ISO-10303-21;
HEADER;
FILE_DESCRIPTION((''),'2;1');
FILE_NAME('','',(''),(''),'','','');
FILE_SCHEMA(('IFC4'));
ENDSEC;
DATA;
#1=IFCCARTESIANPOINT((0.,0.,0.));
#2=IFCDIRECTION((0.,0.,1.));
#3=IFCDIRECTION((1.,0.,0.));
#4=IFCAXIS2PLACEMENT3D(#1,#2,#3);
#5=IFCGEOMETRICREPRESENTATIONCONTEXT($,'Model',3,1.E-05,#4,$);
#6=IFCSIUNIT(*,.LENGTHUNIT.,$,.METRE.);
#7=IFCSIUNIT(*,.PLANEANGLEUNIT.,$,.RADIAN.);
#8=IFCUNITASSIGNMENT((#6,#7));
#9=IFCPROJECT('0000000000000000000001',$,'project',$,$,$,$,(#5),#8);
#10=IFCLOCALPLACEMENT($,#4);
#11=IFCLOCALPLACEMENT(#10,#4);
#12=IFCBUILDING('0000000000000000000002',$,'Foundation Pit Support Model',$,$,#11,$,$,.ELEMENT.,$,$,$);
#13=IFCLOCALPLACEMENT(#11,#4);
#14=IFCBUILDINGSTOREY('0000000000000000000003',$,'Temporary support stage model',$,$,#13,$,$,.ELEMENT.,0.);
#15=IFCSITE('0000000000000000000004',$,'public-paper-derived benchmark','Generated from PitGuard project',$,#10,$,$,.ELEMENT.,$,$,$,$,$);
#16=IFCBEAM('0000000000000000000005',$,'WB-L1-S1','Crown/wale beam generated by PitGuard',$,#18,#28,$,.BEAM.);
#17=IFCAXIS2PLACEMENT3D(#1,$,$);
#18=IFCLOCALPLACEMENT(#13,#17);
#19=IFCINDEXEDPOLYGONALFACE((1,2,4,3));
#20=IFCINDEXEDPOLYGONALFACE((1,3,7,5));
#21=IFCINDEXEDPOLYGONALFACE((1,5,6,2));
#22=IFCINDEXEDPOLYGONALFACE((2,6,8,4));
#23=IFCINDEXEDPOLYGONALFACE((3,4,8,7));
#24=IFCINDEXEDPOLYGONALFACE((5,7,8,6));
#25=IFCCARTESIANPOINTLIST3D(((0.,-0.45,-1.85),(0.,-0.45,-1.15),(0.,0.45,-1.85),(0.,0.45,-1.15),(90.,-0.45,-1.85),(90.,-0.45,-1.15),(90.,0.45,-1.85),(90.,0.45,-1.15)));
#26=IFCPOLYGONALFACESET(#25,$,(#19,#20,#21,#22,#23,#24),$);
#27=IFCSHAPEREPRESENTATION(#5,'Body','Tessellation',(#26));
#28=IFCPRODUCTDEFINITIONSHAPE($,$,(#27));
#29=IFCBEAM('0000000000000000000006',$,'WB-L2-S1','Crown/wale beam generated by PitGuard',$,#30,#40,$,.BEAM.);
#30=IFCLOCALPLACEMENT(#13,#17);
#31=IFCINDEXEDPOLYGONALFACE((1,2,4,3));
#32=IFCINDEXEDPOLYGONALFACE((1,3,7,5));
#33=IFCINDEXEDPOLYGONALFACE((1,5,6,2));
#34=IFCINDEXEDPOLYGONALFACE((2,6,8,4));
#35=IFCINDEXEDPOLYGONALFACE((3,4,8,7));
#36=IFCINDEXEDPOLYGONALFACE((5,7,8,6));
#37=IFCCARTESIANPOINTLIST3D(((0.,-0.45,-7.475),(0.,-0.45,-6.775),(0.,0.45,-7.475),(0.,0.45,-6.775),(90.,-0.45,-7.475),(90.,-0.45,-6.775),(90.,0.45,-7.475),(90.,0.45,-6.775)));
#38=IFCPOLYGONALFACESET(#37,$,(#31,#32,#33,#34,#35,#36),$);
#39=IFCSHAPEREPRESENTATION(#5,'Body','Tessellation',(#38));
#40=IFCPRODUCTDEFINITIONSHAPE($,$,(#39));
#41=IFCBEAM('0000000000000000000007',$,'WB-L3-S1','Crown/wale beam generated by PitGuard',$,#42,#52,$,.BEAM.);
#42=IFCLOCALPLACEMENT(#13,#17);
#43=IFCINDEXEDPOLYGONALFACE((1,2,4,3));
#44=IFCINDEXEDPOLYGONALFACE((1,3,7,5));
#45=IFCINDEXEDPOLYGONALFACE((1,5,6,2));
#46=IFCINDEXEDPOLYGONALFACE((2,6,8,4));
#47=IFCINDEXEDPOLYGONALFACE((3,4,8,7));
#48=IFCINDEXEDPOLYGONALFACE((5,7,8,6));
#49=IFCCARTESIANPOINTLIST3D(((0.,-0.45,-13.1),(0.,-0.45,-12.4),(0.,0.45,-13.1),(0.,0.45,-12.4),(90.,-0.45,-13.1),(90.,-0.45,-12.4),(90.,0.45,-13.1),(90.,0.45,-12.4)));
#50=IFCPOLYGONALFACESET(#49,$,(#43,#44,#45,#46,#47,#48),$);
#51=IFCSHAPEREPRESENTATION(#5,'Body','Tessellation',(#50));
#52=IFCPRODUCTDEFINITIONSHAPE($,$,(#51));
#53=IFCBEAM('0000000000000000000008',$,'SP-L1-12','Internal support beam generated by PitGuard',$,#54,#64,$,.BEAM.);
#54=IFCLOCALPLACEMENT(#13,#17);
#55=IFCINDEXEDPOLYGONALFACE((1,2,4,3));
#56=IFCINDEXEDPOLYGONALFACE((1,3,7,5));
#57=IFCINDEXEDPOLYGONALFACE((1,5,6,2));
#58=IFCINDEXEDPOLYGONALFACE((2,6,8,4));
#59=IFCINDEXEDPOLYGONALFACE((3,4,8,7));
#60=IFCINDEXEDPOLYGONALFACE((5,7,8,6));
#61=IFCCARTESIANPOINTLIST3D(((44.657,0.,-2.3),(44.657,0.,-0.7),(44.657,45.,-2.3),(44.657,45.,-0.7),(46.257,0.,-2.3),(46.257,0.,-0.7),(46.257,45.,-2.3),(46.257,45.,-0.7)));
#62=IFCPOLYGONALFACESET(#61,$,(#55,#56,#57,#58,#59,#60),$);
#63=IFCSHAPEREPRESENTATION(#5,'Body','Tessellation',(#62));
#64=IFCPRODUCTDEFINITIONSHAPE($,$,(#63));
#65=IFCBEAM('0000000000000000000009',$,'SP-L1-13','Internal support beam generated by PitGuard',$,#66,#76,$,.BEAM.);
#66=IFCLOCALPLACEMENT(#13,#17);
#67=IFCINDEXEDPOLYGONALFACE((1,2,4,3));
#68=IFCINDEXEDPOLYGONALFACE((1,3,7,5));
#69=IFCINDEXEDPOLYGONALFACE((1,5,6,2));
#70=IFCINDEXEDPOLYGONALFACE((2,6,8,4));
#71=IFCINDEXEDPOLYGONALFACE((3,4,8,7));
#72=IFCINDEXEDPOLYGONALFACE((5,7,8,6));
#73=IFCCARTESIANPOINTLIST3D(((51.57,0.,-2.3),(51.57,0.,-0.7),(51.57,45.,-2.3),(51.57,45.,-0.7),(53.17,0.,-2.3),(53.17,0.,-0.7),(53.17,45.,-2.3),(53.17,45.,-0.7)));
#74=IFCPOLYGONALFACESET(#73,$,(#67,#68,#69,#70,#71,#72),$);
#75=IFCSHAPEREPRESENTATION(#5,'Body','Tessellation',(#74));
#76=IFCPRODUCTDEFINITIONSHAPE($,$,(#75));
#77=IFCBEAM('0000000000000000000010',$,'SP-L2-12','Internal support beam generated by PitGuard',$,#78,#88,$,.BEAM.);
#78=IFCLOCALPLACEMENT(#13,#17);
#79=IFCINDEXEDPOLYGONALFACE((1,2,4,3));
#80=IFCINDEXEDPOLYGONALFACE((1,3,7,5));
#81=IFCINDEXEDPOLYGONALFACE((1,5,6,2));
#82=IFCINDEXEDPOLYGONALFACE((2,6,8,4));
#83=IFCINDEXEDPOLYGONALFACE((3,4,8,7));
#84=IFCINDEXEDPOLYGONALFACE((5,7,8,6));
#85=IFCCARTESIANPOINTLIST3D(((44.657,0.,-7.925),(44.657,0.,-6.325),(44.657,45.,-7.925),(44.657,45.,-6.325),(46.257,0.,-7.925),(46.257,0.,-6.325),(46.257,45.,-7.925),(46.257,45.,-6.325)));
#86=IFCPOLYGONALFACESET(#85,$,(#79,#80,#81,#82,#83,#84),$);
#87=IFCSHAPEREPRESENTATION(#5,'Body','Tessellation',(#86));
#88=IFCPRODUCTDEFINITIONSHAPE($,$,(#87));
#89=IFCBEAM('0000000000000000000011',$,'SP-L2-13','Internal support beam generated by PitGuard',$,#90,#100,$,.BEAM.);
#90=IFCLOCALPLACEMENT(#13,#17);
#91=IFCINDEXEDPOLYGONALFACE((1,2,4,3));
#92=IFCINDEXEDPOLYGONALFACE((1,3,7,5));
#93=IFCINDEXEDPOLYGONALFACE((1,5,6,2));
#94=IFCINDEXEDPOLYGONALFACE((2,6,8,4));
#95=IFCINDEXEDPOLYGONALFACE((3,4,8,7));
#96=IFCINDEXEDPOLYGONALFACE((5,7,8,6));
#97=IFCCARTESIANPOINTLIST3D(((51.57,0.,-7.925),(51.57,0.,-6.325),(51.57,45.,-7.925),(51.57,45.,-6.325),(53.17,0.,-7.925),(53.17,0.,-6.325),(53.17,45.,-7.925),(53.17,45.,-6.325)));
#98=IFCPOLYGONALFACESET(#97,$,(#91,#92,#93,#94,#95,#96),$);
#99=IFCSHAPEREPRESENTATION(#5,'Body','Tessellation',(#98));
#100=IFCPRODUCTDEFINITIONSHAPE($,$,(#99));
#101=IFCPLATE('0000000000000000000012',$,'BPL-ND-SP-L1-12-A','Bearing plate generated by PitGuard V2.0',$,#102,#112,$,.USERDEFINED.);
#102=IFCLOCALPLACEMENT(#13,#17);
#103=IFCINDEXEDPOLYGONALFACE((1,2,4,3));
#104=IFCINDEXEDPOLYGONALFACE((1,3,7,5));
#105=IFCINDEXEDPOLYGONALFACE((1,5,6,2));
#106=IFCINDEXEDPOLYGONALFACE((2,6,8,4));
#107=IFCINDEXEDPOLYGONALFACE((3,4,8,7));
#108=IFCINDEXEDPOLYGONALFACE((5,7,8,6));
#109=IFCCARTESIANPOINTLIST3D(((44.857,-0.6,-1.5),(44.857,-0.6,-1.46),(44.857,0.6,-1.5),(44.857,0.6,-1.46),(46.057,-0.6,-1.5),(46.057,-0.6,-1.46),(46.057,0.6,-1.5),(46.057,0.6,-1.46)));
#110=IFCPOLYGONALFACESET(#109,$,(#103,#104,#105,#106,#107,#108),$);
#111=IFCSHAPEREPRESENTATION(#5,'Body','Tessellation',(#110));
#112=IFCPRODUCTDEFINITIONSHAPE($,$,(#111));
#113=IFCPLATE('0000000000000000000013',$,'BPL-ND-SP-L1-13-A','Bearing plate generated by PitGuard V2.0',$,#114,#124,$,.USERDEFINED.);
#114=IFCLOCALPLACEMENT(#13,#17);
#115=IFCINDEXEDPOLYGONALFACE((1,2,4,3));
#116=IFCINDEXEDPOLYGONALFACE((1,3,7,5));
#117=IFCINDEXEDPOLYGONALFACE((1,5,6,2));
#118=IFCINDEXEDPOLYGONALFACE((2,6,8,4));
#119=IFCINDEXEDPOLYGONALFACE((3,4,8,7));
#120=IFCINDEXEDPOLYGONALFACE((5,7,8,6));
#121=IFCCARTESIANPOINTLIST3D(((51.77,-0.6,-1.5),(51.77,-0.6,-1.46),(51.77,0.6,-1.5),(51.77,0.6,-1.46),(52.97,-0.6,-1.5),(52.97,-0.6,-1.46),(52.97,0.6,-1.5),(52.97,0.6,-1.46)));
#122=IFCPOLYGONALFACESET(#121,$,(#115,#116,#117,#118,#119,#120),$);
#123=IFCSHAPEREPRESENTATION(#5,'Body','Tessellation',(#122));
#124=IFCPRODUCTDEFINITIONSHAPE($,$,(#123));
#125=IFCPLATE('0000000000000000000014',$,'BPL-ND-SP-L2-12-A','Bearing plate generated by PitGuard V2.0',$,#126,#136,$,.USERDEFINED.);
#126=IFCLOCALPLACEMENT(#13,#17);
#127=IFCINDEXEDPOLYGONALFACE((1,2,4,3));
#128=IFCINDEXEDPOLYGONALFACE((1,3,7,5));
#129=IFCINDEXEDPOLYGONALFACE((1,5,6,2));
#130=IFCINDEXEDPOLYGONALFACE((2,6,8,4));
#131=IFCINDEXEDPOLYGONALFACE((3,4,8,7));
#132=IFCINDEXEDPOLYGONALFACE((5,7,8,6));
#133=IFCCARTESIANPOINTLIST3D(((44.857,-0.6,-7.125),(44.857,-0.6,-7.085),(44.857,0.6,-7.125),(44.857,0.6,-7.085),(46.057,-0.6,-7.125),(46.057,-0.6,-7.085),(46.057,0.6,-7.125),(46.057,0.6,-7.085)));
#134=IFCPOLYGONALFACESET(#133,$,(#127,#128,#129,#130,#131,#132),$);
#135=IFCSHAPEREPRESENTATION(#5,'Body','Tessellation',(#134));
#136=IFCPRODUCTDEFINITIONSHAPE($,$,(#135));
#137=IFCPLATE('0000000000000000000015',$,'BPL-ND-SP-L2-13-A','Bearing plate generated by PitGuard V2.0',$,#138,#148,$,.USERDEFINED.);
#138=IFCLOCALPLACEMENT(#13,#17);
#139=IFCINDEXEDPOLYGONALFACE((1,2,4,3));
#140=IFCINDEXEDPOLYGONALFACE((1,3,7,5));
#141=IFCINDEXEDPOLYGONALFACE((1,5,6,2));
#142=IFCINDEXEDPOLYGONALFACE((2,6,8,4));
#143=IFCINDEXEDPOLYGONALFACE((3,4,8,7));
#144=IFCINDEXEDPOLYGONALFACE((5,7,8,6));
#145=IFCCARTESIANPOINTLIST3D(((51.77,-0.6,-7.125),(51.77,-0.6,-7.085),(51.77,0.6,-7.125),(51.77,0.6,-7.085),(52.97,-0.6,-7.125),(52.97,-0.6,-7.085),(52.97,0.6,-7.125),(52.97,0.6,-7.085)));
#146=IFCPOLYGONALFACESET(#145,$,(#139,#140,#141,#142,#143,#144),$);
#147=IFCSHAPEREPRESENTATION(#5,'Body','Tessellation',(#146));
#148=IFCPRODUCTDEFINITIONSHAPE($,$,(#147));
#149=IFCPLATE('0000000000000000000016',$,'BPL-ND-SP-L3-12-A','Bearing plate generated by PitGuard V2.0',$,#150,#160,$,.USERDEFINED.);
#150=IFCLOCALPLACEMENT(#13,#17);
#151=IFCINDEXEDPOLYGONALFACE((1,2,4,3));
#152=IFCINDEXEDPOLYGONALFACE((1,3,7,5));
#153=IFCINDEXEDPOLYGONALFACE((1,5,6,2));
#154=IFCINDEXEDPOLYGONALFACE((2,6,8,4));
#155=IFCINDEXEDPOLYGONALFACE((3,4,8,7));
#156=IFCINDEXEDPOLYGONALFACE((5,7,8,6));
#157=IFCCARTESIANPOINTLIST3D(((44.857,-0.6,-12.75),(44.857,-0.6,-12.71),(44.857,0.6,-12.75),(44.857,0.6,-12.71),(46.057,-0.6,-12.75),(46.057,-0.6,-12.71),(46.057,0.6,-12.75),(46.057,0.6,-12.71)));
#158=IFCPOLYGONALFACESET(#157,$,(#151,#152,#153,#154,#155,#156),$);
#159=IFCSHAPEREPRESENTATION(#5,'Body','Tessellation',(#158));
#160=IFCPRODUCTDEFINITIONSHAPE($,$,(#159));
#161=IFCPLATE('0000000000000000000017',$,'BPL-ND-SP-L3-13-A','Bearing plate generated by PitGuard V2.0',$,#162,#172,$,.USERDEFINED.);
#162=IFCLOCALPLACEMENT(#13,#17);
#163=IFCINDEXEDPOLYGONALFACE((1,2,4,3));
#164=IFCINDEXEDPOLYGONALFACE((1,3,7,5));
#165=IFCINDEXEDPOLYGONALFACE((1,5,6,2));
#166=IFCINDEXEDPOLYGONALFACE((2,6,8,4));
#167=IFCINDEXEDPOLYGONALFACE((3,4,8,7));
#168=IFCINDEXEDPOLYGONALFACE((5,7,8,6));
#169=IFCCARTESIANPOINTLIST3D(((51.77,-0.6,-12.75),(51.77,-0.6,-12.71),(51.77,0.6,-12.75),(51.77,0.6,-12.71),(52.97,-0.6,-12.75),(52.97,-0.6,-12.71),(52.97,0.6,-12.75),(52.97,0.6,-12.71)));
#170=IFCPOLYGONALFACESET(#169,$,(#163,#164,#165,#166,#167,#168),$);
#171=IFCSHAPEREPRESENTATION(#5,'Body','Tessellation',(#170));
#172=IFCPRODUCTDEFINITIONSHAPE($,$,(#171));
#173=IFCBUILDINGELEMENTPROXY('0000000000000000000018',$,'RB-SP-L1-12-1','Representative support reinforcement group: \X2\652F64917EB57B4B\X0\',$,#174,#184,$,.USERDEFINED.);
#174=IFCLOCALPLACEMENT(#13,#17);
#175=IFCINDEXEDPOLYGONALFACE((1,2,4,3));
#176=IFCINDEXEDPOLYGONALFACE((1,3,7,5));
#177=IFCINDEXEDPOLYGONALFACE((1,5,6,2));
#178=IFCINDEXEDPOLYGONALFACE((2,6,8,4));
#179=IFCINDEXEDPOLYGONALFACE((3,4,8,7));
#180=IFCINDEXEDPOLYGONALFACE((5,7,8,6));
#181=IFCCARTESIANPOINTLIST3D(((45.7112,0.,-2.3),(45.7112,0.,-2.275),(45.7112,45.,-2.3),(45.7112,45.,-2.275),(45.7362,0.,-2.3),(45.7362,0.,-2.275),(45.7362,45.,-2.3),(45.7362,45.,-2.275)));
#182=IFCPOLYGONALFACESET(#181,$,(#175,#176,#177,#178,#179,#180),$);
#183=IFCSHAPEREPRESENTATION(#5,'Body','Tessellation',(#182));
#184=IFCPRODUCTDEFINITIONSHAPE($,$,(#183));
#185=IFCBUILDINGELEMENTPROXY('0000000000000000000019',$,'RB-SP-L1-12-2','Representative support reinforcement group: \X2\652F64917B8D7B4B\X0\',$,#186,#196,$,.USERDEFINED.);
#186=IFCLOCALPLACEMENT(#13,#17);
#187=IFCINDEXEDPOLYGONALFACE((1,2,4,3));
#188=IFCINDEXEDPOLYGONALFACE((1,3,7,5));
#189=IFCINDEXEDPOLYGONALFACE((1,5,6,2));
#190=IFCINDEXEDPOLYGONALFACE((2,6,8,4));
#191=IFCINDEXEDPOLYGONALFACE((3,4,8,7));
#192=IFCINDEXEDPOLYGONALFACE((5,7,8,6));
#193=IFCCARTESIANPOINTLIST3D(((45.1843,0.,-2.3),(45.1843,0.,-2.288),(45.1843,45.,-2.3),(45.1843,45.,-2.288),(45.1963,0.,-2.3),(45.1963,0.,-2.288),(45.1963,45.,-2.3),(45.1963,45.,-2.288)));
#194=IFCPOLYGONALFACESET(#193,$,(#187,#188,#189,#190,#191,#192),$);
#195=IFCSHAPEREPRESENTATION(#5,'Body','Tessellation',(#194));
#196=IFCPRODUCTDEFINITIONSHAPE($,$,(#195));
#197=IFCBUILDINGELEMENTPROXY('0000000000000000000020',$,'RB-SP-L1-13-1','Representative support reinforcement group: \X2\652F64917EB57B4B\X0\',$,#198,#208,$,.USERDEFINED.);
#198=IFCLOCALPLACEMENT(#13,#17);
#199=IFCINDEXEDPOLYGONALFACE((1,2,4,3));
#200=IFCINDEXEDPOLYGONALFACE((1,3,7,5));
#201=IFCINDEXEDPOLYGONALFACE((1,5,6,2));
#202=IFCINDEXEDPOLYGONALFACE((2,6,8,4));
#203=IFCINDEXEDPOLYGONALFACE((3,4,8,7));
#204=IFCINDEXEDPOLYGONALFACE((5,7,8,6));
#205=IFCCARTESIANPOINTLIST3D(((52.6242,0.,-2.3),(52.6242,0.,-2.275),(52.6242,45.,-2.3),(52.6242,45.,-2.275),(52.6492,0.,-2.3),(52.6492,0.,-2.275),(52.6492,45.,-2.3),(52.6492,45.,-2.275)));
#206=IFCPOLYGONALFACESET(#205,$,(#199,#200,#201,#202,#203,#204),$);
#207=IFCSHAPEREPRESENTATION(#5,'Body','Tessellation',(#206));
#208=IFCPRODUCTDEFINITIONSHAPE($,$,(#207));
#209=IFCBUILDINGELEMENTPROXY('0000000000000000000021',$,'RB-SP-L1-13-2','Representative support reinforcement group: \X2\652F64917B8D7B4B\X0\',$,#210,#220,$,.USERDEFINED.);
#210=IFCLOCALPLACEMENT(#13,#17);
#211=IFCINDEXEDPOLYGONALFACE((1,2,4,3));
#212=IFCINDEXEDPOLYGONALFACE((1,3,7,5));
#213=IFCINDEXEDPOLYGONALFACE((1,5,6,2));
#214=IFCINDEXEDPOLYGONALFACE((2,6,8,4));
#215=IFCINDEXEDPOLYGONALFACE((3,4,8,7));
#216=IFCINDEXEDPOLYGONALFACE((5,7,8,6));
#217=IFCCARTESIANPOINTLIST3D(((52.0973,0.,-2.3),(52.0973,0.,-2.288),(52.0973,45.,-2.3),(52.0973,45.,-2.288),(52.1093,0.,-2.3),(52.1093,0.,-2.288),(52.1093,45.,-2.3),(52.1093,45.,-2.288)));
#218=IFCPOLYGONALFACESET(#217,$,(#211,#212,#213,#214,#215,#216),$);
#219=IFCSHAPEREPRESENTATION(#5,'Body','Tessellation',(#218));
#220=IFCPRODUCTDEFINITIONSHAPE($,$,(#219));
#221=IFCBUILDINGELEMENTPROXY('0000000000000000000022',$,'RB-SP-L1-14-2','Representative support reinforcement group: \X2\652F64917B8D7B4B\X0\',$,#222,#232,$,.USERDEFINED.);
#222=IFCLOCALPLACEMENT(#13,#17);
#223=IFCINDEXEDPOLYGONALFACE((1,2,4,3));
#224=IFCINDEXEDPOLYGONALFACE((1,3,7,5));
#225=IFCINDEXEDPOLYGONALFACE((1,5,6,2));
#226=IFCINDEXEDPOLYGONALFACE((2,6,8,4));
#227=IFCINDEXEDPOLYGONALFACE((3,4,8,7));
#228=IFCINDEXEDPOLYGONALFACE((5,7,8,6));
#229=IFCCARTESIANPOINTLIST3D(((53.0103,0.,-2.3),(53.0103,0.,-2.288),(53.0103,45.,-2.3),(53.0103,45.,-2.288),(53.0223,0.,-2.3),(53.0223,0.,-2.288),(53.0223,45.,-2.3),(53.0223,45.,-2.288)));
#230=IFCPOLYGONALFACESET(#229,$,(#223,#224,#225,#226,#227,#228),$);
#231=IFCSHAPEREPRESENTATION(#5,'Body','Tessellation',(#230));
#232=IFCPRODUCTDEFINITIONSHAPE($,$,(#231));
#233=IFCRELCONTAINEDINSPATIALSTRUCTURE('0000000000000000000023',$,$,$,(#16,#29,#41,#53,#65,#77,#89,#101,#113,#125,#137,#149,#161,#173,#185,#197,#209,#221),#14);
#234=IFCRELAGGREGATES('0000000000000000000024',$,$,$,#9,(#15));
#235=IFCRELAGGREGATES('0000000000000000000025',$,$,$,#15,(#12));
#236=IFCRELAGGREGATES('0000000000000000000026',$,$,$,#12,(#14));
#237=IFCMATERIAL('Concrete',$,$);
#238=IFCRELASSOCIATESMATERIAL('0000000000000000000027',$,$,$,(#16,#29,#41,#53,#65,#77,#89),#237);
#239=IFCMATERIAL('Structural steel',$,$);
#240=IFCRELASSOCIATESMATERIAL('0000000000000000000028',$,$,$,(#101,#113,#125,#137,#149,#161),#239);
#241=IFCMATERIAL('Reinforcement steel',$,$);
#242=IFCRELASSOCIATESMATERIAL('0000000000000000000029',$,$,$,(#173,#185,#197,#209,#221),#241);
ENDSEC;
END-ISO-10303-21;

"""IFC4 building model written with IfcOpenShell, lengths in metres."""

from ifc_helpers import new_model, si_unit, frame, origin_with_axes, origin_2d, place, context, project, spatial, rectangle, extrude, material, element, save


model = new_model("IFC4")

# Units and contexts
model_context = context("Model", 3, precision=1e-05, world=origin_with_axes())
ifc_project = project(units=[si_unit("LENGTHUNIT", "METRE"), si_unit("PLANEANGLEUNIT", "RADIAN")], contexts=[model_context])

# Site, building, storey
site_placement = place(None, origin_with_axes())
site = spatial("IfcSite", under=ifc_project, at=site_placement, Name="public-paper-derived benchmark", Description="Generated from PitGuard project", CompositionType="ELEMENT")
building_placement = place(site_placement, origin_with_axes())
building = spatial("IfcBuilding", under=site, at=building_placement, Name="Foundation Pit Support Model", CompositionType="ELEMENT")
storey_placement = place(building_placement, origin_with_axes())
storey = spatial("IfcBuildingStorey", under=building, at=storey_placement, Name="Temporary support stage model", CompositionType="ELEMENT", Elevation=0.0)

# Beams
ifc_material_1 = material(Name="Concrete")
for number, where, z_axis, x_axis, name in (
    (1, (45.0, 0.0, -1.85), (0.0, 0.0, 1.0), (1.0, 0.0, 0.0), "WB-L1-S1"),
    (2, (45.0, 0.0, -7.475), (0.0, 0.0, 1.0), (1.0, 0.0, 0.0), "WB-L2-S1"),
    (3, (45.0, 0.0, -13.1), (0.0, 0.0, 1.0), (1.0, 0.0, 0.0), "WB-L3-S1"),
):
    element("IfcBeam", number, at=place(storey_placement, frame(where, z_axis=z_axis, x_axis=x_axis)), inside=storey, material=ifc_material_1, Name=name, Description="Crown/wale beam generated by PitGuard", PredefinedType="BEAM", context=model_context, shape_type="SweptSolid", body=[
        extrude(rectangle(XDim=90.0, YDim=0.9, at=origin_2d()), origin_with_axes(), (0.0, 0.0, 1.0), 0.7),
    ])
for number, where, z_axis, x_axis, name in (
    (4, (45.457, 22.5, -2.3), (0.0, 0.0, 1.0), (0.0, 1.0, 0.0), "SP-L1-12"),
    (5, (52.37, 22.5, -2.3), (0.0, 0.0, 1.0), (0.0, 1.0, 0.0), "SP-L1-13"),
    (6, (45.457, 22.5, -7.925), (0.0, 0.0, 1.0), (0.0, 1.0, 0.0), "SP-L2-12"),
    (7, (52.37, 22.5, -7.925), (0.0, 0.0, 1.0), (0.0, 1.0, 0.0), "SP-L2-13"),
):
    element("IfcBeam", number, at=place(storey_placement, frame(where, z_axis=z_axis, x_axis=x_axis)), inside=storey, material=ifc_material_1, Name=name, Description="Internal support beam generated by PitGuard", PredefinedType="BEAM", context=model_context, shape_type="SweptSolid", body=[
        extrude(rectangle(XDim=45.0, YDim=1.6, at=origin_2d()), origin_with_axes(), (0.0, 0.0, 1.0), 1.6),
    ])

# Plates
ifc_material_2 = material(Name="Structural steel")
for number, where, z_axis, x_axis, name in (
    (8, (45.457, 0.0, -1.5), (0.0, 0.0, 1.0), (1.0, 0.0, 0.0), "BPL-ND-SP-L1-12-A"),
    (9, (52.37, 0.0, -1.5), (0.0, 0.0, 1.0), (1.0, 0.0, 0.0), "BPL-ND-SP-L1-13-A"),
    (10, (45.457, 0.0, -7.125), (0.0, 0.0, 1.0), (1.0, 0.0, 0.0), "BPL-ND-SP-L2-12-A"),
    (11, (52.37, 0.0, -7.125), (0.0, 0.0, 1.0), (1.0, 0.0, 0.0), "BPL-ND-SP-L2-13-A"),
    (12, (45.457, 0.0, -12.75), (0.0, 0.0, 1.0), (1.0, 0.0, 0.0), "BPL-ND-SP-L3-12-A"),
    (13, (52.37, 0.0, -12.75), (0.0, 0.0, 1.0), (1.0, 0.0, 0.0), "BPL-ND-SP-L3-13-A"),
):
    element("IfcPlate", number, at=place(storey_placement, frame(where, z_axis=z_axis, x_axis=x_axis)), inside=storey, material=ifc_material_2, Name=name, Description="Bearing plate generated by PitGuard V2.0", PredefinedType="USERDEFINED", context=model_context, shape_type="SweptSolid", body=[
        extrude(rectangle(XDim=1.2, YDim=1.2, at=origin_2d()), origin_with_axes(), (0.0, 0.0, 1.0), 0.04),
    ])

# Building element proxies
ifc_material_3 = material(Name="Reinforcement steel")
proxy_1_placement = place(storey_placement, frame((45.7237, 22.5, -2.3), z_axis=(0.0, 0.0, 1.0), x_axis=(0.0, 1.0, 0.0)))
element("IfcBuildingElementProxy", 14, at=proxy_1_placement, inside=storey, material=ifc_material_3, Name="RB-SP-L1-12-1", Description="Representative support reinforcement group: 支撑纵筋", PredefinedType="USERDEFINED", context=model_context, shape_type="SweptSolid", body=[
    extrude(rectangle(XDim=45.0, YDim=0.025, at=origin_2d()), origin_with_axes(), (0.0, 0.0, 1.0), 0.025),
])
proxy_2_placement = place(storey_placement, frame((45.1903, 22.5, -2.3), z_axis=(0.0, 0.0, 1.0), x_axis=(0.0, 1.0, 0.0)))
element("IfcBuildingElementProxy", 15, at=proxy_2_placement, inside=storey, material=ifc_material_3, Name="RB-SP-L1-12-2", Description="Representative support reinforcement group: 支撑箍筋", PredefinedType="USERDEFINED", context=model_context, shape_type="SweptSolid", body=[
    extrude(rectangle(XDim=45.0, YDim=0.012, at=origin_2d()), origin_with_axes(), (0.0, 0.0, 1.0), 0.012),
])
proxy_3_placement = place(storey_placement, frame((52.6367, 22.5, -2.3), z_axis=(0.0, 0.0, 1.0), x_axis=(0.0, 1.0, 0.0)))
element("IfcBuildingElementProxy", 16, at=proxy_3_placement, inside=storey, material=ifc_material_3, Name="RB-SP-L1-13-1", Description="Representative support reinforcement group: 支撑纵筋", PredefinedType="USERDEFINED", context=model_context, shape_type="SweptSolid", body=[
    extrude(rectangle(XDim=45.0, YDim=0.025, at=origin_2d()), origin_with_axes(), (0.0, 0.0, 1.0), 0.025),
])
for number, where, z_axis, x_axis, name in (
    (17, (52.1033, 22.5, -2.3), (0.0, 0.0, 1.0), (0.0, 1.0, 0.0), "RB-SP-L1-13-2"),
    (18, (53.0163, 22.5, -2.3), (0.0, 0.0, 1.0), (0.0, 1.0, 0.0), "RB-SP-L1-14-2"),
):
    element("IfcBuildingElementProxy", number, at=place(storey_placement, frame(where, z_axis=z_axis, x_axis=x_axis)), inside=storey, material=ifc_material_3, Name=name, Description="Representative support reinforcement group: 支撑箍筋", PredefinedType="USERDEFINED", context=model_context, shape_type="SweptSolid", body=[
        extrude(rectangle(XDim=45.0, YDim=0.012, at=origin_2d()), origin_with_axes(), (0.0, 0.0, 1.0), 0.012),
    ])

save(model, "model.ifc")
